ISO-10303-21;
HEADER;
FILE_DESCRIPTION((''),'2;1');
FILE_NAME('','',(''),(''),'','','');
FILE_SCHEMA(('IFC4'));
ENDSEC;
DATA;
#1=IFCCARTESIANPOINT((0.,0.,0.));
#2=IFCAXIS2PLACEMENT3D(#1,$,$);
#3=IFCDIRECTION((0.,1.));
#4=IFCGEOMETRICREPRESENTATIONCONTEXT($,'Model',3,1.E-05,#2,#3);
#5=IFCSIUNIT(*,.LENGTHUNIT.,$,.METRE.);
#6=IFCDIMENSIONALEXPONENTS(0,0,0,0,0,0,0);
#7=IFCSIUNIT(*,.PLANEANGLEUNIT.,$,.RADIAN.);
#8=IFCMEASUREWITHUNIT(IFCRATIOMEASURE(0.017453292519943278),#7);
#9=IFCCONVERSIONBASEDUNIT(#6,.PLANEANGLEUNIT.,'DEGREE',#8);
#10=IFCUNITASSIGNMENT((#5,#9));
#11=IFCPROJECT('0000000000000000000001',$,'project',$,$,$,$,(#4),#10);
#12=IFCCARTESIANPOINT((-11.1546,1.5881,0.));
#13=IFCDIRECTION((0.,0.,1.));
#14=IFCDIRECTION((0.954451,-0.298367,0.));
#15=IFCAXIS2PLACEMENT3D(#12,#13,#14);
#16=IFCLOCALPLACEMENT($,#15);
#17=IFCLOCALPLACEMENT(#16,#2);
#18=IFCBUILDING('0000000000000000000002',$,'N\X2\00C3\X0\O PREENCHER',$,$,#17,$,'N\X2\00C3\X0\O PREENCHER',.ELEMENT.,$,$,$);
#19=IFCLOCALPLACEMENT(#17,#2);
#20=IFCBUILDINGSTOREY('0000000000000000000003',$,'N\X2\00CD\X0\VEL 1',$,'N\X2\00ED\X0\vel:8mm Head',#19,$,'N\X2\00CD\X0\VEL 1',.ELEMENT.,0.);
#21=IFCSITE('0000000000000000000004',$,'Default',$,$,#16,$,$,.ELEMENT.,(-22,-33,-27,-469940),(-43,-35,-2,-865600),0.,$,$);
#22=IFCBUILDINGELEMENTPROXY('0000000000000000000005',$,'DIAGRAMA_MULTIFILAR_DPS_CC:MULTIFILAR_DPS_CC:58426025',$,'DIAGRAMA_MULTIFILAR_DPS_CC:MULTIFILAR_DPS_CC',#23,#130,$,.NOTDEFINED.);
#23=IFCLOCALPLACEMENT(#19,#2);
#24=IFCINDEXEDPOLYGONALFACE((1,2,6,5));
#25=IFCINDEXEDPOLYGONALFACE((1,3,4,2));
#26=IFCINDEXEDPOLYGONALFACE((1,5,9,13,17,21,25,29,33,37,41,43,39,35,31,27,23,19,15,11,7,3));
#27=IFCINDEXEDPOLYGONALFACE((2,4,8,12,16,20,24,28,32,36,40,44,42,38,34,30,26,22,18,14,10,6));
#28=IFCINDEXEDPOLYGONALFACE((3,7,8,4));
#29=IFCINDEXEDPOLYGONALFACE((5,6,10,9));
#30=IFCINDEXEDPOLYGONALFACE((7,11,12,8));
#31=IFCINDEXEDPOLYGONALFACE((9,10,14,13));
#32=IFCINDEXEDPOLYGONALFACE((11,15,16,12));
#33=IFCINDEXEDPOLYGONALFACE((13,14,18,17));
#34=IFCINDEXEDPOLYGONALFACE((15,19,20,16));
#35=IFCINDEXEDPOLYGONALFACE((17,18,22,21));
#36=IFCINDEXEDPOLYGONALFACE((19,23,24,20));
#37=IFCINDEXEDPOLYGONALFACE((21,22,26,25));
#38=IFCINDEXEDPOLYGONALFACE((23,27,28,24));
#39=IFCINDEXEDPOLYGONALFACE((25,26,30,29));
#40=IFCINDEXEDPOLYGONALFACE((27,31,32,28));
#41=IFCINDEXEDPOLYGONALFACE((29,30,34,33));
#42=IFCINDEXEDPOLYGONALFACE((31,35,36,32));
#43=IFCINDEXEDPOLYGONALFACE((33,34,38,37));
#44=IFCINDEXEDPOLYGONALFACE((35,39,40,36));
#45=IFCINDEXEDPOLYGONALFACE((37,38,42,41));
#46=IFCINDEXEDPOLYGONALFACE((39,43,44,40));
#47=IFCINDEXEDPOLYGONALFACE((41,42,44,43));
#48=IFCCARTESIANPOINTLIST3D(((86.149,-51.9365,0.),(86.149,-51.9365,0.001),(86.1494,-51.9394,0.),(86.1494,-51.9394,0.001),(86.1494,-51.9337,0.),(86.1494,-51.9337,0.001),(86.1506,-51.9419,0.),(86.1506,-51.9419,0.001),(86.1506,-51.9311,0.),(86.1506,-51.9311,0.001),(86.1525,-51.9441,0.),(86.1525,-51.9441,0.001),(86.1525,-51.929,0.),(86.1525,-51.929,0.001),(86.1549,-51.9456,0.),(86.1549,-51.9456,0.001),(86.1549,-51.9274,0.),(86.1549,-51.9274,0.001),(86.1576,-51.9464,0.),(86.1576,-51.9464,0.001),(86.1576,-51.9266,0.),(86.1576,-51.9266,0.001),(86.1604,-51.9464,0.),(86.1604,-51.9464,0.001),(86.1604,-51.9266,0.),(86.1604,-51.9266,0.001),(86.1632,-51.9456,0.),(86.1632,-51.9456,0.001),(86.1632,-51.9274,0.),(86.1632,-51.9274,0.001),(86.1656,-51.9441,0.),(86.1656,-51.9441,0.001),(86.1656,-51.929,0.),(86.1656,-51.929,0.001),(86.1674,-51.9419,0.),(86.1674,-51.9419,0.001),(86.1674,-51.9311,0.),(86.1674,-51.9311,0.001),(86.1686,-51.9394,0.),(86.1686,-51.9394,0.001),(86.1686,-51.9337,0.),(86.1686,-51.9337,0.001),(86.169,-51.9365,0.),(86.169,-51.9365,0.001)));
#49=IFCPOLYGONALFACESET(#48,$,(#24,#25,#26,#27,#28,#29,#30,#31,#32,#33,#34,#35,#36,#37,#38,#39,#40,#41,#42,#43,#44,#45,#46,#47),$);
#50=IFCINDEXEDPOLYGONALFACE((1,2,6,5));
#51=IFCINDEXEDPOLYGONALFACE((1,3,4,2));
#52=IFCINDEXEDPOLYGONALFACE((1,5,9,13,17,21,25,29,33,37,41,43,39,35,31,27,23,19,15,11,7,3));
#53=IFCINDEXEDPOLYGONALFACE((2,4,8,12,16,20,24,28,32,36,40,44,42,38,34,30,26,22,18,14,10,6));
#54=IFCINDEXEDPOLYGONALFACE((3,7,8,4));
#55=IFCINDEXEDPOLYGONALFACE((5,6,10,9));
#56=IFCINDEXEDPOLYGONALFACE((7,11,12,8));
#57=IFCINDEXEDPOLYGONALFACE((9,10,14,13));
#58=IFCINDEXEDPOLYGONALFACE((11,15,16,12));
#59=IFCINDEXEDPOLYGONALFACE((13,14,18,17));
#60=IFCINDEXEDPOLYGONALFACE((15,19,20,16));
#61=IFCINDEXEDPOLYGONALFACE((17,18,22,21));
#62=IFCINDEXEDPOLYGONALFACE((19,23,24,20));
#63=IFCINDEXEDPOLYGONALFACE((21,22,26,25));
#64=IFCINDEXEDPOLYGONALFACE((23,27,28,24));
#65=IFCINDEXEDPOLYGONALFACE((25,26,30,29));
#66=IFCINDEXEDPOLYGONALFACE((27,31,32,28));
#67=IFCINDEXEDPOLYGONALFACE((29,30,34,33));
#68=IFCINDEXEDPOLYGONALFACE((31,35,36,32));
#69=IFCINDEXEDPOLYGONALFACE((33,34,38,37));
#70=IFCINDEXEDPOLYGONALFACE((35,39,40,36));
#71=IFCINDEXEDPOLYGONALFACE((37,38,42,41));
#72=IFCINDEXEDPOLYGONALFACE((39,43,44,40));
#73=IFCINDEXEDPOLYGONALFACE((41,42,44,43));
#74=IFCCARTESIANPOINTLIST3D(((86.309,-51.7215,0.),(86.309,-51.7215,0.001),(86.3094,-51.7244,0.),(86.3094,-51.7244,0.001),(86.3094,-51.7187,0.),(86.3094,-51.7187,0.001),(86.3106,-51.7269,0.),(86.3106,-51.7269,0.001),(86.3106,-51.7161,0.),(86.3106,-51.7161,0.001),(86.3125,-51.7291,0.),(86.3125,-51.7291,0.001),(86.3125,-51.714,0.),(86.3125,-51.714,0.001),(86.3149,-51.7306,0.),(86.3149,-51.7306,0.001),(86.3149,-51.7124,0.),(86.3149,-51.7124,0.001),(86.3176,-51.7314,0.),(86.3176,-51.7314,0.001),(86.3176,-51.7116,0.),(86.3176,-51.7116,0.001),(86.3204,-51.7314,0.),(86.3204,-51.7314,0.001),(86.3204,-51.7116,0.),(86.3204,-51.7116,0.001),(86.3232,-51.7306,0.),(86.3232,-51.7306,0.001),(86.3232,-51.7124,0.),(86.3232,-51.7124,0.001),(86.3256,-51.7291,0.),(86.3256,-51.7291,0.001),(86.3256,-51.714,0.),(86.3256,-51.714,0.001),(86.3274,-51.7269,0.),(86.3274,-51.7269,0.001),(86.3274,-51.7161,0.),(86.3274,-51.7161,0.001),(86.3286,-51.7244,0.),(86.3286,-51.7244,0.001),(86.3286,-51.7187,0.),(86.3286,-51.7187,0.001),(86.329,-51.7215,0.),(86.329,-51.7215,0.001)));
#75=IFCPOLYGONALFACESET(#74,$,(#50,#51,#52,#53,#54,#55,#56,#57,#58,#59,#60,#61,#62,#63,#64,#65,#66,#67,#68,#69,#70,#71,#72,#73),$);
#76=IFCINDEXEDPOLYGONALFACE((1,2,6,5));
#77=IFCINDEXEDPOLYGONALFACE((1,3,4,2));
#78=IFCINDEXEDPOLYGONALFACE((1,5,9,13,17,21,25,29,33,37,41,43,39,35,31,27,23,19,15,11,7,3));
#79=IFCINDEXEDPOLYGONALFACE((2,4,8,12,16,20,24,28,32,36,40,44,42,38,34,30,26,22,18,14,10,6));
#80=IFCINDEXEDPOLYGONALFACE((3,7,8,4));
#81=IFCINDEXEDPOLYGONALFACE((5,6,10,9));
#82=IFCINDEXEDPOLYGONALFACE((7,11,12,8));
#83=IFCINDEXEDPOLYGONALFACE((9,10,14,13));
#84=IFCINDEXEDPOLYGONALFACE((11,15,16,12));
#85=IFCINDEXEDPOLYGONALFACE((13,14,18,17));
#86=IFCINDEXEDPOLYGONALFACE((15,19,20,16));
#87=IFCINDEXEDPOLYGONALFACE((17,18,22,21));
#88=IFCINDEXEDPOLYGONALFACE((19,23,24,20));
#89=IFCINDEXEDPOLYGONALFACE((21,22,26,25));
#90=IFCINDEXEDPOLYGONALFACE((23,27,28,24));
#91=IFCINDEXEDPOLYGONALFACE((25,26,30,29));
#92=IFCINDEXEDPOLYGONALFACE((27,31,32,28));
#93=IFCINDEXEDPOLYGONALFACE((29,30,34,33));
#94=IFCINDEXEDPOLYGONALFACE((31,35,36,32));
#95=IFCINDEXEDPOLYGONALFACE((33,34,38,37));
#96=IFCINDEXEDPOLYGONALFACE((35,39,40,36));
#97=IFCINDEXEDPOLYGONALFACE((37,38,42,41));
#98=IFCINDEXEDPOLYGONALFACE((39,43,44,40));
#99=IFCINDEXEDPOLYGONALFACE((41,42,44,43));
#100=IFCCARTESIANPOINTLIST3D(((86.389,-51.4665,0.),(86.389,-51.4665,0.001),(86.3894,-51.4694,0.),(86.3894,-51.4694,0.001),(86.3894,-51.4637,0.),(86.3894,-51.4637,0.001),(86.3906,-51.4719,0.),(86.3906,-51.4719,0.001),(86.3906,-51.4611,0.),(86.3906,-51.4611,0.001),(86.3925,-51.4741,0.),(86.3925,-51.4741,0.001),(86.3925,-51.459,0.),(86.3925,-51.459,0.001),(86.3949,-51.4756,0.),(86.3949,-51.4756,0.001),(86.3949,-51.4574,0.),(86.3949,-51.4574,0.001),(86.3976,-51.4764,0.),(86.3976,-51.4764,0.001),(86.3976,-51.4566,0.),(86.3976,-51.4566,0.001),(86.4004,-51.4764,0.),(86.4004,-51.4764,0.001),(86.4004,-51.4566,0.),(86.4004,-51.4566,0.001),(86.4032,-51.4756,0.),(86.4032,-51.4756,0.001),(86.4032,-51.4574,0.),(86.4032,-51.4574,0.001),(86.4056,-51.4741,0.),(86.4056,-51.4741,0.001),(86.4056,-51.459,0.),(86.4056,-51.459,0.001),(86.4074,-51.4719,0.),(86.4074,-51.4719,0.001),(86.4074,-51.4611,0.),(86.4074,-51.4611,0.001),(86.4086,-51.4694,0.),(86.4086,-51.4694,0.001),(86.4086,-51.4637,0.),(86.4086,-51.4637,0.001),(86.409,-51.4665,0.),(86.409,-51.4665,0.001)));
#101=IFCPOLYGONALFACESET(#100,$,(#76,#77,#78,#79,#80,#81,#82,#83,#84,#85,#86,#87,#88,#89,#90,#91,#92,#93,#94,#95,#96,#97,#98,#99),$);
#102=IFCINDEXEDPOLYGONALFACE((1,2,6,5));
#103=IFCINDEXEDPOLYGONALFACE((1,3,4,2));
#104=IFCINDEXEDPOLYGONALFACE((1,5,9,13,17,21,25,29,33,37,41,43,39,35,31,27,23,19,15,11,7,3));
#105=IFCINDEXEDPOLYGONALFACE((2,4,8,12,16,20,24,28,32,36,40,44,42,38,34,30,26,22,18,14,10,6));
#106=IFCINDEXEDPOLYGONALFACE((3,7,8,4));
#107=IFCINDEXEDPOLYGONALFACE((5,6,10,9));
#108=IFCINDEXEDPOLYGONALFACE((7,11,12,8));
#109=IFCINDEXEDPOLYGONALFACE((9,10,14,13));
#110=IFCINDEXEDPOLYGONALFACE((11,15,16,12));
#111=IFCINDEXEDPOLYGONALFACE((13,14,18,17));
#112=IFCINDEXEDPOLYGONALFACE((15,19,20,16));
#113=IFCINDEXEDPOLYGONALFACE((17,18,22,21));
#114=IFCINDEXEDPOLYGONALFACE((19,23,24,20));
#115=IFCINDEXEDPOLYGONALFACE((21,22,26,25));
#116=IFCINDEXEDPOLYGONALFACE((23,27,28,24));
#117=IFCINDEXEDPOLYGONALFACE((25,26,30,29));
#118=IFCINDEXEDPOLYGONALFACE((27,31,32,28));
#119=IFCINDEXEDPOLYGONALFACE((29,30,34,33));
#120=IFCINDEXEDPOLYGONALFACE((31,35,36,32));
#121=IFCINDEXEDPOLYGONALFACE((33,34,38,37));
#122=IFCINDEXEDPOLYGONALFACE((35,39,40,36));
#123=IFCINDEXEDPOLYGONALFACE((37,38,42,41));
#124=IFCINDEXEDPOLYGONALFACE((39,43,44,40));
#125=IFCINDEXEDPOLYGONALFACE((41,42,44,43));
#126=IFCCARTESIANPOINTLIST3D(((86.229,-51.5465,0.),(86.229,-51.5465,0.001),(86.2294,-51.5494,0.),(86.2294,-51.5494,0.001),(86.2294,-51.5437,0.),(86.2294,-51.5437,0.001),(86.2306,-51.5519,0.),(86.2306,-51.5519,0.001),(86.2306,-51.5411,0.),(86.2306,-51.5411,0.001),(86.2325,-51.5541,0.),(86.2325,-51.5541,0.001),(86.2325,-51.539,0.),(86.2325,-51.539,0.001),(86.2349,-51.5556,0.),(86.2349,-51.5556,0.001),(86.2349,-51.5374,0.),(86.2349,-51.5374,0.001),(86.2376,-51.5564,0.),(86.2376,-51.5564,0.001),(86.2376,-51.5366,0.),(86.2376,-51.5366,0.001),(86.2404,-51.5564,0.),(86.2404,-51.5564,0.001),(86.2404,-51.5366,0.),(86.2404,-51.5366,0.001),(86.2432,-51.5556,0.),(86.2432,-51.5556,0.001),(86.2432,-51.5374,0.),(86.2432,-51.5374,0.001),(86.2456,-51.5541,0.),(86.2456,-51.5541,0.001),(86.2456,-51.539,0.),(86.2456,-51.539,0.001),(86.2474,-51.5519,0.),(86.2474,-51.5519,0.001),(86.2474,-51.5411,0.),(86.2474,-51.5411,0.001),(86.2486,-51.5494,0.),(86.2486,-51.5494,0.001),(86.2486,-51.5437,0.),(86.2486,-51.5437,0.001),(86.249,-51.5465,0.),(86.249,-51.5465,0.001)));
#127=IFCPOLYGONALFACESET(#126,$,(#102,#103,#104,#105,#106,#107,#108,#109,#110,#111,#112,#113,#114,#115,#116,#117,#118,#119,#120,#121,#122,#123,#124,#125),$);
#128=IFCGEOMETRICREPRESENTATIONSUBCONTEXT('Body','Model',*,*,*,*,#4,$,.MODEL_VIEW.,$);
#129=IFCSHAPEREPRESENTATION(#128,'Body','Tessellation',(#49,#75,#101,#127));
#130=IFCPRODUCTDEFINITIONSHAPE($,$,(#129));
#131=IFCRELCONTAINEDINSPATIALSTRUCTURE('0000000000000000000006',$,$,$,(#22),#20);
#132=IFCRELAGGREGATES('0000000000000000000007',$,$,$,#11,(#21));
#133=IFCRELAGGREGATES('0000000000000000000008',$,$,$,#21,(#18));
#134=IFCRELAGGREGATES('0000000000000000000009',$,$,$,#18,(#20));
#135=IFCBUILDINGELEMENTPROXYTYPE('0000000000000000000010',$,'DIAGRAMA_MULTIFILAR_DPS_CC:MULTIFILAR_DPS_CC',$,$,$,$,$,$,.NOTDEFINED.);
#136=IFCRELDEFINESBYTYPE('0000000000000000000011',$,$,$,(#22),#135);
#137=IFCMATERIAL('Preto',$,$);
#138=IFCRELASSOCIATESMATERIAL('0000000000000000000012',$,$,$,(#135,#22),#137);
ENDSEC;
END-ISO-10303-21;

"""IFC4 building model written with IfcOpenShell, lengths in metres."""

from ifc_helpers import new_model, entity, si_unit, converted_unit, direction, frame, origin, place, context, subcontext, project, spatial, arc, indexed_curve, outline, extrude, source, transform, mapped, material, type_object, type_shapes, element, save


model = new_model("IFC4")

# Units and contexts
model_context = context("Model", 3, precision=1e-05, world=origin(), true_north=direction((0.0, 1.0)))
body_context = subcontext(model_context, "Body", "Model", "MODEL_VIEW")
ifc_project = project(units=[si_unit("LENGTHUNIT", "METRE"), converted_unit("PLANEANGLEUNIT", "DEGREE", entity("IfcRatioMeasure", 0.017453292519943278), si_unit("PLANEANGLEUNIT", "RADIAN"), dimensions=[0, 0, 0, 0, 0, 0, 0])], contexts=[model_context])

# Site, building, storey
site_placement = place(None, frame((-11.1546, 1.5881, 0.0), z_axis=(0.0, 0.0, 1.0), x_axis=(0.954451, -0.298367, 0.0)))
site = spatial("IfcSite", under=ifc_project, at=site_placement, Name="Default", CompositionType="ELEMENT", RefLatitude=(-22, -33, -27, -469940), RefLongitude=(-43, -35, -2, -865600), RefElevation=0.0)
building_placement = place(site_placement, origin())
building = spatial("IfcBuilding", under=site, at=building_placement, Name="NÃO PREENCHER", LongName="NÃO PREENCHER", CompositionType="ELEMENT")
storey_placement = place(building_placement, origin())
storey = spatial("IfcBuildingStorey", under=building, at=storey_placement, Name="NÍVEL 1", ObjectType="Nível:8mm Head", LongName="NÍVEL 1", CompositionType="ELEMENT", Elevation=0.0)

# Building element proxy
ifc_material = material(Name="Preto")
building_element_proxy_type_1 = type_object("IfcBuildingElementProxyType", Name="DIAGRAMA_MULTIFILAR_DPS_CC:MULTIFILAR_DPS_CC", PredefinedType="NOTDEFINED", material=ifc_material)
shared_shape_1 = source(origin(), body_context, "Body", "SweptSolid", [
    extrude(outline(indexed_curve([(-0.01, 0.0), (0.0, -0.01), (0.01, 0.0), (0.0, 0.01)], segments=[arc(1, 2, 3), arc(3, 4, 1)], self_intersect=False)), frame((0.0116, 0.0116, 0.0)), (0.0, 0.0, 1.0), 0.001),
    extrude(outline(indexed_curve([(-0.01, 0.0), (0.0, -0.01), (0.01, 0.0), (0.0, 0.01)], segments=[arc(1, 2, 3), arc(3, 4, 1)], self_intersect=False)), frame((0.1716, 0.2266, 0.0)), (0.0, 0.0, 1.0), 0.001),
    extrude(outline(indexed_curve([(-0.01, 0.0), (0.0, -0.01), (0.01, 0.0), (0.0, 0.01)], segments=[arc(1, 2, 3), arc(3, 4, 1)], self_intersect=False)), frame((0.2516, 0.4816, 0.0)), (0.0, 0.0, 1.0), 0.001),
    extrude(outline(indexed_curve([(-0.01, 0.0), (0.0, -0.01), (0.01, 0.0), (0.0, 0.01)], segments=[arc(1, 2, 3), arc(3, 4, 1)], self_intersect=False)), frame((0.0916, 0.4016, 0.0)), (0.0, 0.0, 1.0), 0.001),
])
type_shapes(building_element_proxy_type_1, [shared_shape_1])
for number, where, name in (
    (1, (86.1474, -51.9481, 0.0), "DIAGRAMA_MULTIFILAR_DPS_CC:MULTIFILAR_DPS_CC:58426025"),
):
    element("IfcBuildingElementProxy", number, at=place(storey_placement, frame(where)), inside=storey, type_object=building_element_proxy_type_1, material=ifc_material, Name=name, ObjectType="DIAGRAMA_MULTIFILAR_DPS_CC:MULTIFILAR_DPS_CC", PredefinedType="NOTDEFINED", context=body_context, shape_type="MappedRepresentation", body=[
        mapped(shared_shape_1, transform((0.0, 0.0, 0.0), scale=1.0)),
    ])

save(model, "model.ifc")
